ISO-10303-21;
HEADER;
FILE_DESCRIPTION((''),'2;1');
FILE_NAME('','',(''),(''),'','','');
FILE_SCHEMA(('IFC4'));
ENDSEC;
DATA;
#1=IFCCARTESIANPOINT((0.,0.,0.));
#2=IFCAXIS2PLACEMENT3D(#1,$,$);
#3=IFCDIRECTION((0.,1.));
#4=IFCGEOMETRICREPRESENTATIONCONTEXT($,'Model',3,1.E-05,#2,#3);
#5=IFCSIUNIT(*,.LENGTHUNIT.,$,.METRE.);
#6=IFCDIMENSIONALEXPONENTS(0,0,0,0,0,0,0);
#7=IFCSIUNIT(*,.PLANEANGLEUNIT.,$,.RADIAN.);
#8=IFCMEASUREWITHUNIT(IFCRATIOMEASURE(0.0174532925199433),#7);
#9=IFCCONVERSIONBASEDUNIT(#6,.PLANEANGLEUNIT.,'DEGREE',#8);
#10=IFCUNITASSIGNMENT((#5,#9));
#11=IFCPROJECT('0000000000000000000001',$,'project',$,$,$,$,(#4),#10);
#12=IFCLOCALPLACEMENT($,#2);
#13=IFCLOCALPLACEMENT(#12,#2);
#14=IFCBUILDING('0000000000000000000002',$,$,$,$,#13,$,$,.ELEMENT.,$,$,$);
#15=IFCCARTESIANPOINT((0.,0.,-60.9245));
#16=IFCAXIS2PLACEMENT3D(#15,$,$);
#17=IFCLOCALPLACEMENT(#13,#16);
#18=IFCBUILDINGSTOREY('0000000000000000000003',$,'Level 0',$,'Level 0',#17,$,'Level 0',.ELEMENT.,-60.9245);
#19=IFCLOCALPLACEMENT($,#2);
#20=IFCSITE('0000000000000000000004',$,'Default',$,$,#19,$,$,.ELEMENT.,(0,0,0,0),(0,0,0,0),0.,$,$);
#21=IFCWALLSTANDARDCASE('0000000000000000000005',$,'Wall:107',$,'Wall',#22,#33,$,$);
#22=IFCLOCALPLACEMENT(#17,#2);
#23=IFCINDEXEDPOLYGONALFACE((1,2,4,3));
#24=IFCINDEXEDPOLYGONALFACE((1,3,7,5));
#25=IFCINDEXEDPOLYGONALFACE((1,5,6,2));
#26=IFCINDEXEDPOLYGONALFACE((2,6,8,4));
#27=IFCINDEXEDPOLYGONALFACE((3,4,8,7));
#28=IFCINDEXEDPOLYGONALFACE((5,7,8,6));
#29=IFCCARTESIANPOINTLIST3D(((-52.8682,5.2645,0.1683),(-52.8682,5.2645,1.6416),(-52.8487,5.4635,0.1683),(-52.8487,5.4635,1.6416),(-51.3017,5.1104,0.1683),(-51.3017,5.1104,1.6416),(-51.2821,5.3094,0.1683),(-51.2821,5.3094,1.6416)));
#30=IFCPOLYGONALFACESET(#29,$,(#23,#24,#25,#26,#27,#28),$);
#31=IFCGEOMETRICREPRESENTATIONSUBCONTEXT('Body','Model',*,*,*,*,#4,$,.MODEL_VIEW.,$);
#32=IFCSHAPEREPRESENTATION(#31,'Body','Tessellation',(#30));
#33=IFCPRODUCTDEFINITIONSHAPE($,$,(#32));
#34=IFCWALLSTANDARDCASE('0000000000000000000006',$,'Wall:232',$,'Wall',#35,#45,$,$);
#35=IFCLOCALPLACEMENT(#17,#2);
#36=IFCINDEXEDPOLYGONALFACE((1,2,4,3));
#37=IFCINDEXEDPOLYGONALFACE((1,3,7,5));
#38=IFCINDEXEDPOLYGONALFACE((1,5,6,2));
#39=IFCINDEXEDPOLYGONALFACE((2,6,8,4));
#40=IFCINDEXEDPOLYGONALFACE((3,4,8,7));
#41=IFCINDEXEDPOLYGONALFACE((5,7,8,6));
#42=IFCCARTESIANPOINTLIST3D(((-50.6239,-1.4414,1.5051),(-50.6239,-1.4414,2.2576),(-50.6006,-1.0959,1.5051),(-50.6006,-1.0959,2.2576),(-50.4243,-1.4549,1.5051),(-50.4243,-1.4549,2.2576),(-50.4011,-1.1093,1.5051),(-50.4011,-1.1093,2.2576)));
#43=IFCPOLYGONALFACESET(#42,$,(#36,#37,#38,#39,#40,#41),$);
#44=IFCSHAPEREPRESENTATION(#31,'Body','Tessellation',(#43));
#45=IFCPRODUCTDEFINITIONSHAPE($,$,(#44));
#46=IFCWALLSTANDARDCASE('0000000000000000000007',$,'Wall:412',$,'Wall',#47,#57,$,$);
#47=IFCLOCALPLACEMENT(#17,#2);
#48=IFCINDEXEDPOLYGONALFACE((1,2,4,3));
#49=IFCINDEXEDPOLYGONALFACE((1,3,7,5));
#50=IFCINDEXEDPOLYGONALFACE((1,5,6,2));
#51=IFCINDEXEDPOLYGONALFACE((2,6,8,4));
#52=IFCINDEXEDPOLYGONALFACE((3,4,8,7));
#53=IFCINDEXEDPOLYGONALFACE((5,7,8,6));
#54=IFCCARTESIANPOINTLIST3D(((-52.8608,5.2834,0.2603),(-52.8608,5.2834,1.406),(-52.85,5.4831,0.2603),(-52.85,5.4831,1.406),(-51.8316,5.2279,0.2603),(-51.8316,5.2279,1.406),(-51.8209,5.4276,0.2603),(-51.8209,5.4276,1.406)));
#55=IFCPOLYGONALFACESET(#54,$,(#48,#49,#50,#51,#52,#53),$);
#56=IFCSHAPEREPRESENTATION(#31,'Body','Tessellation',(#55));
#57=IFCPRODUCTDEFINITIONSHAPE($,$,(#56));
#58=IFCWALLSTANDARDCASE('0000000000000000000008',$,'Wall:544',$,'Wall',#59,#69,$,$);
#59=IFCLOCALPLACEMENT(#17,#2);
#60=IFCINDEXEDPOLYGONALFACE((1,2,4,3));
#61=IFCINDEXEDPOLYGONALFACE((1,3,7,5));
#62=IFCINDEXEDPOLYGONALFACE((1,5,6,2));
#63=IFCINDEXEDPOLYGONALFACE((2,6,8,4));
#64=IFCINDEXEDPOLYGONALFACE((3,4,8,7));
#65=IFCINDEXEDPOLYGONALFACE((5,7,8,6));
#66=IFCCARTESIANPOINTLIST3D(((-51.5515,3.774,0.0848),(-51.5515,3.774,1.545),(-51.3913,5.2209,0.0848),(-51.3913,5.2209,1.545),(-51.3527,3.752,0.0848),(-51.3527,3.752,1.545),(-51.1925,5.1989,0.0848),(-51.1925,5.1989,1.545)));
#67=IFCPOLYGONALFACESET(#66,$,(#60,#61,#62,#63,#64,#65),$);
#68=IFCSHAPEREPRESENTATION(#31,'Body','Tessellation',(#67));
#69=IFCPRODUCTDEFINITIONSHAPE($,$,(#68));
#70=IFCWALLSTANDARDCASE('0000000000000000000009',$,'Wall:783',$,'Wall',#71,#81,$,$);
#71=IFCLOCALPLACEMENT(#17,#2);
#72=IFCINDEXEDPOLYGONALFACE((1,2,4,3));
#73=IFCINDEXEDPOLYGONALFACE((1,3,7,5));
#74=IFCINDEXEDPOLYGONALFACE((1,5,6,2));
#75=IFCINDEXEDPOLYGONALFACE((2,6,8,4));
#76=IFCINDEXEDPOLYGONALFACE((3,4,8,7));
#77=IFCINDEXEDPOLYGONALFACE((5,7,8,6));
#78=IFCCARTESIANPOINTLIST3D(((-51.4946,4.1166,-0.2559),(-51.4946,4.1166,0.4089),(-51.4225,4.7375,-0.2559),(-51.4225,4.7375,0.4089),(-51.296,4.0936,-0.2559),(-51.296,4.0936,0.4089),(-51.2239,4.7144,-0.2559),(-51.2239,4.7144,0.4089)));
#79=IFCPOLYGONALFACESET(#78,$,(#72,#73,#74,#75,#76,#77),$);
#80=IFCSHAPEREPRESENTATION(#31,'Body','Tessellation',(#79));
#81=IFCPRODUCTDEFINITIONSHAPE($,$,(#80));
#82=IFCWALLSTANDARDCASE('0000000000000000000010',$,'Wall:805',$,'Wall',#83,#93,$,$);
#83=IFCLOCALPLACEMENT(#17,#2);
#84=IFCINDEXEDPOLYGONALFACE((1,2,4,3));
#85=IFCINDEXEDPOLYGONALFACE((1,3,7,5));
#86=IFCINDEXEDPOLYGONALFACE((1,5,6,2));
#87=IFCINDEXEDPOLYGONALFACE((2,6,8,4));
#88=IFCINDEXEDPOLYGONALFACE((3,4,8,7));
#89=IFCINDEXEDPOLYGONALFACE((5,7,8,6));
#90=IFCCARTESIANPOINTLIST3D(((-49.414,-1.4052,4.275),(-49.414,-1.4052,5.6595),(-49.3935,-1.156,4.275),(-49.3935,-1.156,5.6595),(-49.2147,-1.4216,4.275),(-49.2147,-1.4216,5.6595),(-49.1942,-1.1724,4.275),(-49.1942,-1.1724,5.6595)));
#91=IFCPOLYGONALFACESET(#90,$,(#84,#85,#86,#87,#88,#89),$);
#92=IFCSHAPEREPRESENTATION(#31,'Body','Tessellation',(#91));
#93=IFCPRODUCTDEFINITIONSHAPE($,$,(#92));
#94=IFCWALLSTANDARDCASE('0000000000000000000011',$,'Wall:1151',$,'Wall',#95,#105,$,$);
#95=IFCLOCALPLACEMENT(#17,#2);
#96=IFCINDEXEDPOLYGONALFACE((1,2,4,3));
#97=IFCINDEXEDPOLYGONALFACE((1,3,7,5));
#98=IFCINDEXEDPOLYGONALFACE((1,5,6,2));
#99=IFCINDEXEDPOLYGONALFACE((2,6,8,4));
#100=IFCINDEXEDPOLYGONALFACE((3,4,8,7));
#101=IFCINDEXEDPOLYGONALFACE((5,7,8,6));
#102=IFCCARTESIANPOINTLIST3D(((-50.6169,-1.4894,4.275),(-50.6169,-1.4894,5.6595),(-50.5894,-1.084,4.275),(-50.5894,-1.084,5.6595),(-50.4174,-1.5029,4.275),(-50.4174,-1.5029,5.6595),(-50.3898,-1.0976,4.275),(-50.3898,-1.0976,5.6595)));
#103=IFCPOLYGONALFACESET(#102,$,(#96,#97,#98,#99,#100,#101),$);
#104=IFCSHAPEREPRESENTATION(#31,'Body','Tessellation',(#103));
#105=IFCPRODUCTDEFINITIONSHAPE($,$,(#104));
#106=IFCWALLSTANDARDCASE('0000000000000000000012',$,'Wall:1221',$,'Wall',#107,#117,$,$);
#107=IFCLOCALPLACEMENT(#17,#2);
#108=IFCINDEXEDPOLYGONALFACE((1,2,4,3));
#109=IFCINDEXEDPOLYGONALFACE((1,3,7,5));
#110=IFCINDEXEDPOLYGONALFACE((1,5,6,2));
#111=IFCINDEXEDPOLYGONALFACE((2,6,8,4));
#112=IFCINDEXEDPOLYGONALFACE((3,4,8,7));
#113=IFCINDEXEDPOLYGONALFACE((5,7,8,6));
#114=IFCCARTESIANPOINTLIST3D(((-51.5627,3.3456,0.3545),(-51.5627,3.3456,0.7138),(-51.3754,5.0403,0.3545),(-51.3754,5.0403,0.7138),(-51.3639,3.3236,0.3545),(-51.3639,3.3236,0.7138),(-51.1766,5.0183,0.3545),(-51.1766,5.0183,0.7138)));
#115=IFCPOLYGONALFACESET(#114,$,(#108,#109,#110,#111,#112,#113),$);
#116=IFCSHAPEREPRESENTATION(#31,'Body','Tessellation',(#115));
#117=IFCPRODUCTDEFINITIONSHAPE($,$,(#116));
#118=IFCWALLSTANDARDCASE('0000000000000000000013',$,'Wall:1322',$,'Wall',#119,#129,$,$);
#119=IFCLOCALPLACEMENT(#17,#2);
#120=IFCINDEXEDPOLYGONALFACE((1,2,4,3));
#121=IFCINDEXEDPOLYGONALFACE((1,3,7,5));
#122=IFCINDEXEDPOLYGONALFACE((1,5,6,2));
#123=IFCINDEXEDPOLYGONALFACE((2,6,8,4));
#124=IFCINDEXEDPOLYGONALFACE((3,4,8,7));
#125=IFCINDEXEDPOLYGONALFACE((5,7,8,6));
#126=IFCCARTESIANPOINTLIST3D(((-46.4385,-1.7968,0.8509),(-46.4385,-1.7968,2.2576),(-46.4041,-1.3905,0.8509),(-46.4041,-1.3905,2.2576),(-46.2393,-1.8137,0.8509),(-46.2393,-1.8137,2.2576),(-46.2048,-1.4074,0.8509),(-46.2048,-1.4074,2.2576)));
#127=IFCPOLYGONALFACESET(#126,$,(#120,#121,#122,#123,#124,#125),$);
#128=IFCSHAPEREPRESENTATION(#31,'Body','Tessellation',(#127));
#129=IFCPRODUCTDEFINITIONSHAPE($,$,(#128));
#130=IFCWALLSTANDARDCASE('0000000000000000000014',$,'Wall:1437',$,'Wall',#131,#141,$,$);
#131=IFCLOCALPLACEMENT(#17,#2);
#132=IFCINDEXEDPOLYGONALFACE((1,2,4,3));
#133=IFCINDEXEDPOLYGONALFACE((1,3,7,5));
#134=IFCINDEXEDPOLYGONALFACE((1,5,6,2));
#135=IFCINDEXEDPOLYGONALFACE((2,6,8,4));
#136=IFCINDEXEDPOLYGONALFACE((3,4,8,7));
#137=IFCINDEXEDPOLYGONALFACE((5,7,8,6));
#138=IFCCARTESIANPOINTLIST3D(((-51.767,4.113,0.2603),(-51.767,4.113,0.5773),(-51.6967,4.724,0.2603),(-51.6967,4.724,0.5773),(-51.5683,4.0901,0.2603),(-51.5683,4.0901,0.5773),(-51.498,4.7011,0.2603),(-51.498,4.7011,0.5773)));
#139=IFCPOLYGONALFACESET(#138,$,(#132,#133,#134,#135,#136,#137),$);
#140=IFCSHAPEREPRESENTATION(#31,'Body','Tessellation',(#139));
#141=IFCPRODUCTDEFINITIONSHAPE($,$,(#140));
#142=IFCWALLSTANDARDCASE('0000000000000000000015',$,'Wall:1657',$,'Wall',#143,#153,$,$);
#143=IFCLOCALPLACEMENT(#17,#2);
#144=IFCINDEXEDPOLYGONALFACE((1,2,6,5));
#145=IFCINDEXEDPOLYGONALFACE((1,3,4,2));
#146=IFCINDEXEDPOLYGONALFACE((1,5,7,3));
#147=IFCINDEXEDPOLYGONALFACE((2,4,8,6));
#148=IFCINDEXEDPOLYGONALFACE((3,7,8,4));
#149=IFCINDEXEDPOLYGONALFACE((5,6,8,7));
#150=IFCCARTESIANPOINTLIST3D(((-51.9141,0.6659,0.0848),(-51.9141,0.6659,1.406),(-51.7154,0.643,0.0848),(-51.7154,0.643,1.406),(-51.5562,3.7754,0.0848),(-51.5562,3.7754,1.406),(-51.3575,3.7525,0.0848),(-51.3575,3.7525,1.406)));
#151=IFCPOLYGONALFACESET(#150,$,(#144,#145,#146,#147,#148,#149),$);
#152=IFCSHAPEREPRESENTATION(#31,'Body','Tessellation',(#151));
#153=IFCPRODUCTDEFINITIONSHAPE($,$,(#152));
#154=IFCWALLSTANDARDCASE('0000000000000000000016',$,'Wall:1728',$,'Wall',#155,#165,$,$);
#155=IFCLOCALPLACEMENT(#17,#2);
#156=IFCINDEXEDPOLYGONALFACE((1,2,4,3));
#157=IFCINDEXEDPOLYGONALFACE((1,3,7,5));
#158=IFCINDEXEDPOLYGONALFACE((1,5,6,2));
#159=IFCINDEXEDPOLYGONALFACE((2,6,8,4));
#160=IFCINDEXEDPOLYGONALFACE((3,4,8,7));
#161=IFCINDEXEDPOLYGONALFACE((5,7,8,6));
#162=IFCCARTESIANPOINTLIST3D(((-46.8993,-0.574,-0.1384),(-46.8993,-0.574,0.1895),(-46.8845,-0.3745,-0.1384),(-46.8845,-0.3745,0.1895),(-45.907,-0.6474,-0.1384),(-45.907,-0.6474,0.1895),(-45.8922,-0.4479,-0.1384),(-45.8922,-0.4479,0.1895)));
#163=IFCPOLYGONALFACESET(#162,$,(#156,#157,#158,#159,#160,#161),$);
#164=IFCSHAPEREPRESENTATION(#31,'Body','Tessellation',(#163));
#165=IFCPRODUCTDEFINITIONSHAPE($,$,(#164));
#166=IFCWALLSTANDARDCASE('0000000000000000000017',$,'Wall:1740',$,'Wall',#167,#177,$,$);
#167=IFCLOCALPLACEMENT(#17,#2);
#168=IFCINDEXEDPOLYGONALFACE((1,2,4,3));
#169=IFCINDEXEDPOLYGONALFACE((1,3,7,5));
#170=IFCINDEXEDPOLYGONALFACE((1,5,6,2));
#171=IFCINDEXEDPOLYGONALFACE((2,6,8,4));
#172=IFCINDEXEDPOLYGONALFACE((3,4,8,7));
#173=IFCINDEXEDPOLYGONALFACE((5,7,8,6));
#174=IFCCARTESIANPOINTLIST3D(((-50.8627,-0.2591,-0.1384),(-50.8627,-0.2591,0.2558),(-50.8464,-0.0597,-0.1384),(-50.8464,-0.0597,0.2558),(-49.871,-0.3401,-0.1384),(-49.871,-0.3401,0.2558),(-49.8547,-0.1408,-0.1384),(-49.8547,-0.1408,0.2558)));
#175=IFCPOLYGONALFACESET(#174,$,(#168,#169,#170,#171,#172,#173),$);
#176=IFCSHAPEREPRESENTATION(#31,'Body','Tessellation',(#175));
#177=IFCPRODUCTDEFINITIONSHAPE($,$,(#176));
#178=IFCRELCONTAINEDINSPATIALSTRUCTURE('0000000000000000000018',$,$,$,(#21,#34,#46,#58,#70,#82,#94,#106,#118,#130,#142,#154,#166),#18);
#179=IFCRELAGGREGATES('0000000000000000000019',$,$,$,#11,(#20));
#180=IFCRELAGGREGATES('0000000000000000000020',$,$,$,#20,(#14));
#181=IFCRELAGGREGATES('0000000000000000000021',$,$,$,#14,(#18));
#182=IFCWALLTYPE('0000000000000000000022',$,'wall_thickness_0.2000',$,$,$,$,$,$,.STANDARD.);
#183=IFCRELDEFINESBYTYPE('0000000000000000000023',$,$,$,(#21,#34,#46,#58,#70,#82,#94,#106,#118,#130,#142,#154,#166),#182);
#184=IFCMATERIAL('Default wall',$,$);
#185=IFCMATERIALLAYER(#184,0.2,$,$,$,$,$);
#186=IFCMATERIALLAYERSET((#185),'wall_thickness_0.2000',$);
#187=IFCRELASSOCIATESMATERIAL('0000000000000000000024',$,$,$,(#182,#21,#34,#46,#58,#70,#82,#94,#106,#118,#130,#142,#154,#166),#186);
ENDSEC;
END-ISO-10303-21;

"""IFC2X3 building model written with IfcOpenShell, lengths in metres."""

from ifc_helpers import new_model, entity, si_unit, converted_unit, direction, frame, origin, place, context, subcontext, project, spatial, polyline, outline, extrude, material, layer, layer_set, layer_usage, type_object, element, save


model = new_model("IFC2X3")

# Units and contexts
model_context = context("Model", 3, precision=1e-05, world=origin(), true_north=direction((0.0, 1.0)))
body_context = subcontext(model_context, "Body", "Model", "MODEL_VIEW")
ifc_project = project(units=[si_unit("LENGTHUNIT", "METRE"), converted_unit("PLANEANGLEUNIT", "DEGREE", entity("IfcRatioMeasure", 0.0174532925199433), si_unit("PLANEANGLEUNIT", "RADIAN"), dimensions=[0, 0, 0, 0, 0, 0, 0])], contexts=[model_context])

# Site, building, storey
site_placement = place(None, origin())
site = spatial("IfcSite", under=ifc_project, at=site_placement, Name="Default", CompositionType="ELEMENT", RefLatitude=(0, 0, 0, 0), RefLongitude=(0, 0, 0, 0), RefElevation=0.0)
placement_1 = place(None, origin())
building_placement = place(placement_1, origin())
building = spatial("IfcBuilding", under=site, at=building_placement, CompositionType="ELEMENT")
storey_placement = place(building_placement, frame((0.0, 0.0, -60.9245)))
storey = spatial("IfcBuildingStorey", under=building, at=storey_placement, Name="Level 0", ObjectType="Level 0", LongName="Level 0", CompositionType="ELEMENT", Elevation=-60.9245)

# Walls
ifc_material = material(Name="Default wall")
ifc_layer = layer(ifc_material, 0.2)
ifc_layer_set = layer_set([ifc_layer], Name="wall_thickness_0.2000")
ifc_layer_usage = layer_usage(ifc_layer_set, "AXIS2", "POSITIVE", -0.1)
wall_type = type_object("IfcWallType", Name="wall_thickness_0.2000", PredefinedType="STANDARD", material=ifc_layer_set)
placement_2 = place(building_placement, frame((0.0, 0.0, -60.7562)))
wall_1_placement = place(placement_2, frame((-51.2919, 5.2099, 0.0), z_axis=(0.0, 0.0, 1.0), x_axis=(-0.995198, 0.097885, 0.0)))
element("IfcWallStandardCase", 1, at=wall_1_placement, inside=storey, type_object=wall_type, material=ifc_layer_usage, Name="Wall:107", ObjectType="Wall", context=body_context, shape_type="SweptSolid", body=[
    extrude(outline(polyline([(1.5741, -0.1), (1.5741, 0.1), (0.0, 0.1), (0.0, -0.1), (1.5741, -0.1)])), origin(), (0.0, 0.0, 1.0), 1.4733),
])
placement_3 = place(building_placement, frame((0.0, 0.0, -59.4194)))
wall_2_placement = place(placement_3, frame((-50.5241, -1.4482, 0.0), z_axis=(0.0, 0.0, 1.0), x_axis=(0.067106, 0.997746, 0.0)))
element("IfcWallStandardCase", 2, at=wall_2_placement, inside=storey, type_object=wall_type, material=ifc_layer_usage, Name="Wall:232", ObjectType="Wall", context=body_context, shape_type="SweptSolid", body=[
    extrude(outline(polyline([(0.3464, -0.1), (0.3464, 0.1), (0.0, 0.1), (0.0, -0.1), (0.3464, -0.1)])), origin(), (0.0, 0.0, 1.0), 0.7525),
])
placement_4 = place(building_placement, frame((0.0, 0.0, -60.6642)))
wall_3_placement = place(placement_4, frame((-51.8262, 5.3277, 0.0), z_axis=(0.0, 0.0, 1.0), x_axis=(-0.99855, 0.053824, 0.0)))
element("IfcWallStandardCase", 3, at=wall_3_placement, inside=storey, type_object=wall_type, material=ifc_layer_usage, Name="Wall:412", ObjectType="Wall", context=body_context, shape_type="SweptSolid", body=[
    extrude(outline(polyline([(1.0307, -0.1), (1.0307, 0.1), (0.0, 0.1), (0.0, -0.1), (1.0307, -0.1)])), origin(), (0.0, 0.0, 1.0), 1.1457),
])
placement_5 = place(building_placement, frame((0.0, 0.0, -60.8397)))
wall_4_placement = place(placement_5, frame((-51.4521, 3.763, 0.0), z_axis=(0.0, 0.0, 1.0), x_axis=(0.110051, 0.993926, 0.0)))
element("IfcWallStandardCase", 4, at=wall_4_placement, inside=storey, type_object=wall_type, material=ifc_layer_usage, Name="Wall:544", ObjectType="Wall", context=body_context, shape_type="SweptSolid", body=[
    extrude(outline(polyline([(1.4557, -0.1), (1.4557, 0.1), (0.0, 0.1), (0.0, -0.1), (1.4557, -0.1)])), origin(), (0.0, 0.0, 1.0), 1.4602),
])
placement_6 = place(building_placement, frame((0.0, 0.0, -61.1804)))
wall_5_placement = place(placement_6, frame((-51.3232, 4.7259, 0.0), z_axis=(0.0, 0.0, 1.0), x_axis=(-0.115332, -0.993327, 0.0)))
element("IfcWallStandardCase", 5, at=wall_5_placement, inside=storey, type_object=wall_type, material=ifc_layer_usage, Name="Wall:783", ObjectType="Wall", context=body_context, shape_type="SweptSolid", body=[
    extrude(outline(polyline([(0.625, -0.1), (0.625, 0.1), (0.0, 0.1), (0.0, -0.1), (0.625, -0.1)])), origin(), (0.0, 0.0, 1.0), 0.6648),
])
placement_7 = place(building_placement, frame((0.0, 0.0, -56.6495)))
wall_6_placement = place(placement_7, frame((-49.2938, -1.1642, 0.0), z_axis=(0.0, 0.0, 1.0), x_axis=(-0.081955, -0.996636, 0.0)))
element("IfcWallStandardCase", 6, at=wall_6_placement, inside=storey, type_object=wall_type, material=ifc_layer_usage, Name="Wall:805", ObjectType="Wall", context=body_context, shape_type="SweptSolid", body=[
    extrude(outline(polyline([(0.25, -0.1), (0.25, 0.1), (0.0, 0.1), (0.0, -0.1), (0.25, -0.1)])), origin(), (0.0, 0.0, 1.0), 1.3845),
])
placement_8 = place(building_placement, frame((0.0, 0.0, -56.6495)))
wall_7_placement = place(placement_8, frame((-50.4896, -1.0908, 0.0), z_axis=(0.0, 0.0, 1.0), x_axis=(-0.067754, -0.997702, 0.0)))
element("IfcWallStandardCase", 7, at=wall_7_placement, inside=storey, type_object=wall_type, material=ifc_layer_usage, Name="Wall:1151", ObjectType="Wall", context=body_context, shape_type="SweptSolid", body=[
    extrude(outline(polyline([(0.4063, -0.1), (0.4063, 0.1), (0.0, 0.1), (0.0, -0.1), (0.4063, -0.1)])), origin(), (0.0, 0.0, 1.0), 1.3845),
])
placement_9 = place(building_placement, frame((0.0, 0.0, -60.57)))
wall_8_placement = place(placement_9, frame((-51.4633, 3.3346, 0.0), z_axis=(0.0, 0.0, 1.0), x_axis=(0.10985, 0.993948, 0.0)))
element("IfcWallStandardCase", 8, at=wall_8_placement, inside=storey, type_object=wall_type, material=ifc_layer_usage, Name="Wall:1221", ObjectType="Wall", context=body_context, shape_type="SweptSolid", body=[
    extrude(outline(polyline([(1.705, -0.1), (1.705, 0.1), (0.0, 0.1), (0.0, -0.1), (1.705, -0.1)])), origin(), (0.0, 0.0, 1.0), 0.3593),
])
placement_10 = place(building_placement, frame((0.0, 0.0, -60.0736)))
wall_9_placement = place(placement_10, frame((-46.3044, -1.399, 0.0), z_axis=(0.0, 0.0, 1.0), x_axis=(-0.08453, -0.996421, 0.0)))
element("IfcWallStandardCase", 9, at=wall_9_placement, inside=storey, type_object=wall_type, material=ifc_layer_usage, Name="Wall:1322", ObjectType="Wall", context=body_context, shape_type="SweptSolid", body=[
    extrude(outline(polyline([(0.4078, -0.1), (0.4078, 0.1), (0.0, 0.1), (0.0, -0.1), (0.4078, -0.1)])), origin(), (0.0, 0.0, 1.0), 1.4068),
])
placement_11 = place(building_placement, frame((0.0, 0.0, -60.6642)))
wall_10_placement = place(placement_11, frame((-51.6676, 4.1016, 0.0), z_axis=(0.0, 0.0, 1.0), x_axis=(0.114211, 0.993456, 0.0)))
element("IfcWallStandardCase", 10, at=wall_10_placement, inside=storey, type_object=wall_type, material=ifc_layer_usage, Name="Wall:1437", ObjectType="Wall", context=body_context, shape_type="SweptSolid", body=[
    extrude(outline(polyline([(0.615, -0.1), (0.615, 0.1), (0.0, 0.1), (0.0, -0.1), (0.615, -0.1)])), origin(), (0.0, 0.0, 1.0), 0.317),
])
placement_12 = place(building_placement, frame((0.0, 0.0, -60.8397)))
wall_11_placement = place(placement_12, frame((-51.8148, 0.6545, 0.0), z_axis=(0.0, 0.0, 1.0), x_axis=(0.114358, 0.99344, 0.0)))
element("IfcWallStandardCase", 11, at=wall_11_placement, inside=storey, type_object=wall_type, material=ifc_layer_usage, Name="Wall:1657", ObjectType="Wall", context=body_context, shape_type="SweptSolid", body=[
    extrude(outline(polyline([(3.13, -0.1), (3.13, 0.1), (0.0, 0.1), (0.0, -0.1), (3.13, -0.1)])), origin(), (0.0, 0.0, 1.0), 1.3213),
])
placement_13 = place(building_placement, frame((0.0, 0.0, -61.0629)))
wall_12_placement = place(placement_13, frame((-46.8919, -0.4743, 0.0), z_axis=(0.0, 0.0, 1.0), x_axis=(0.997276, -0.073762, 0.0)))
element("IfcWallStandardCase", 12, at=wall_12_placement, inside=storey, type_object=wall_type, material=ifc_layer_usage, Name="Wall:1728", ObjectType="Wall", context=body_context, shape_type="SweptSolid", body=[
    extrude(outline(polyline([(0.995, -0.1), (0.995, 0.1), (0.0, 0.1), (0.0, -0.1), (0.995, -0.1)])), origin(), (0.0, 0.0, 1.0), 0.3279),
])
placement_14 = place(building_placement, frame((0.0, 0.0, -61.0629)))
wall_13_placement = place(placement_14, frame((-50.8546, -0.1594, 0.0), z_axis=(0.0, 0.0, 1.0), x_axis=(0.996678, -0.081437, 0.0)))
element("IfcWallStandardCase", 13, at=wall_13_placement, inside=storey, type_object=wall_type, material=ifc_layer_usage, Name="Wall:1740", ObjectType="Wall", context=body_context, shape_type="SweptSolid", body=[
    extrude(outline(polyline([(0.995, -0.1), (0.995, 0.1), (0.0, 0.1), (0.0, -0.1), (0.995, -0.1)])), origin(), (0.0, 0.0, 1.0), 0.3942),
])

save(model, "model.ifc")
